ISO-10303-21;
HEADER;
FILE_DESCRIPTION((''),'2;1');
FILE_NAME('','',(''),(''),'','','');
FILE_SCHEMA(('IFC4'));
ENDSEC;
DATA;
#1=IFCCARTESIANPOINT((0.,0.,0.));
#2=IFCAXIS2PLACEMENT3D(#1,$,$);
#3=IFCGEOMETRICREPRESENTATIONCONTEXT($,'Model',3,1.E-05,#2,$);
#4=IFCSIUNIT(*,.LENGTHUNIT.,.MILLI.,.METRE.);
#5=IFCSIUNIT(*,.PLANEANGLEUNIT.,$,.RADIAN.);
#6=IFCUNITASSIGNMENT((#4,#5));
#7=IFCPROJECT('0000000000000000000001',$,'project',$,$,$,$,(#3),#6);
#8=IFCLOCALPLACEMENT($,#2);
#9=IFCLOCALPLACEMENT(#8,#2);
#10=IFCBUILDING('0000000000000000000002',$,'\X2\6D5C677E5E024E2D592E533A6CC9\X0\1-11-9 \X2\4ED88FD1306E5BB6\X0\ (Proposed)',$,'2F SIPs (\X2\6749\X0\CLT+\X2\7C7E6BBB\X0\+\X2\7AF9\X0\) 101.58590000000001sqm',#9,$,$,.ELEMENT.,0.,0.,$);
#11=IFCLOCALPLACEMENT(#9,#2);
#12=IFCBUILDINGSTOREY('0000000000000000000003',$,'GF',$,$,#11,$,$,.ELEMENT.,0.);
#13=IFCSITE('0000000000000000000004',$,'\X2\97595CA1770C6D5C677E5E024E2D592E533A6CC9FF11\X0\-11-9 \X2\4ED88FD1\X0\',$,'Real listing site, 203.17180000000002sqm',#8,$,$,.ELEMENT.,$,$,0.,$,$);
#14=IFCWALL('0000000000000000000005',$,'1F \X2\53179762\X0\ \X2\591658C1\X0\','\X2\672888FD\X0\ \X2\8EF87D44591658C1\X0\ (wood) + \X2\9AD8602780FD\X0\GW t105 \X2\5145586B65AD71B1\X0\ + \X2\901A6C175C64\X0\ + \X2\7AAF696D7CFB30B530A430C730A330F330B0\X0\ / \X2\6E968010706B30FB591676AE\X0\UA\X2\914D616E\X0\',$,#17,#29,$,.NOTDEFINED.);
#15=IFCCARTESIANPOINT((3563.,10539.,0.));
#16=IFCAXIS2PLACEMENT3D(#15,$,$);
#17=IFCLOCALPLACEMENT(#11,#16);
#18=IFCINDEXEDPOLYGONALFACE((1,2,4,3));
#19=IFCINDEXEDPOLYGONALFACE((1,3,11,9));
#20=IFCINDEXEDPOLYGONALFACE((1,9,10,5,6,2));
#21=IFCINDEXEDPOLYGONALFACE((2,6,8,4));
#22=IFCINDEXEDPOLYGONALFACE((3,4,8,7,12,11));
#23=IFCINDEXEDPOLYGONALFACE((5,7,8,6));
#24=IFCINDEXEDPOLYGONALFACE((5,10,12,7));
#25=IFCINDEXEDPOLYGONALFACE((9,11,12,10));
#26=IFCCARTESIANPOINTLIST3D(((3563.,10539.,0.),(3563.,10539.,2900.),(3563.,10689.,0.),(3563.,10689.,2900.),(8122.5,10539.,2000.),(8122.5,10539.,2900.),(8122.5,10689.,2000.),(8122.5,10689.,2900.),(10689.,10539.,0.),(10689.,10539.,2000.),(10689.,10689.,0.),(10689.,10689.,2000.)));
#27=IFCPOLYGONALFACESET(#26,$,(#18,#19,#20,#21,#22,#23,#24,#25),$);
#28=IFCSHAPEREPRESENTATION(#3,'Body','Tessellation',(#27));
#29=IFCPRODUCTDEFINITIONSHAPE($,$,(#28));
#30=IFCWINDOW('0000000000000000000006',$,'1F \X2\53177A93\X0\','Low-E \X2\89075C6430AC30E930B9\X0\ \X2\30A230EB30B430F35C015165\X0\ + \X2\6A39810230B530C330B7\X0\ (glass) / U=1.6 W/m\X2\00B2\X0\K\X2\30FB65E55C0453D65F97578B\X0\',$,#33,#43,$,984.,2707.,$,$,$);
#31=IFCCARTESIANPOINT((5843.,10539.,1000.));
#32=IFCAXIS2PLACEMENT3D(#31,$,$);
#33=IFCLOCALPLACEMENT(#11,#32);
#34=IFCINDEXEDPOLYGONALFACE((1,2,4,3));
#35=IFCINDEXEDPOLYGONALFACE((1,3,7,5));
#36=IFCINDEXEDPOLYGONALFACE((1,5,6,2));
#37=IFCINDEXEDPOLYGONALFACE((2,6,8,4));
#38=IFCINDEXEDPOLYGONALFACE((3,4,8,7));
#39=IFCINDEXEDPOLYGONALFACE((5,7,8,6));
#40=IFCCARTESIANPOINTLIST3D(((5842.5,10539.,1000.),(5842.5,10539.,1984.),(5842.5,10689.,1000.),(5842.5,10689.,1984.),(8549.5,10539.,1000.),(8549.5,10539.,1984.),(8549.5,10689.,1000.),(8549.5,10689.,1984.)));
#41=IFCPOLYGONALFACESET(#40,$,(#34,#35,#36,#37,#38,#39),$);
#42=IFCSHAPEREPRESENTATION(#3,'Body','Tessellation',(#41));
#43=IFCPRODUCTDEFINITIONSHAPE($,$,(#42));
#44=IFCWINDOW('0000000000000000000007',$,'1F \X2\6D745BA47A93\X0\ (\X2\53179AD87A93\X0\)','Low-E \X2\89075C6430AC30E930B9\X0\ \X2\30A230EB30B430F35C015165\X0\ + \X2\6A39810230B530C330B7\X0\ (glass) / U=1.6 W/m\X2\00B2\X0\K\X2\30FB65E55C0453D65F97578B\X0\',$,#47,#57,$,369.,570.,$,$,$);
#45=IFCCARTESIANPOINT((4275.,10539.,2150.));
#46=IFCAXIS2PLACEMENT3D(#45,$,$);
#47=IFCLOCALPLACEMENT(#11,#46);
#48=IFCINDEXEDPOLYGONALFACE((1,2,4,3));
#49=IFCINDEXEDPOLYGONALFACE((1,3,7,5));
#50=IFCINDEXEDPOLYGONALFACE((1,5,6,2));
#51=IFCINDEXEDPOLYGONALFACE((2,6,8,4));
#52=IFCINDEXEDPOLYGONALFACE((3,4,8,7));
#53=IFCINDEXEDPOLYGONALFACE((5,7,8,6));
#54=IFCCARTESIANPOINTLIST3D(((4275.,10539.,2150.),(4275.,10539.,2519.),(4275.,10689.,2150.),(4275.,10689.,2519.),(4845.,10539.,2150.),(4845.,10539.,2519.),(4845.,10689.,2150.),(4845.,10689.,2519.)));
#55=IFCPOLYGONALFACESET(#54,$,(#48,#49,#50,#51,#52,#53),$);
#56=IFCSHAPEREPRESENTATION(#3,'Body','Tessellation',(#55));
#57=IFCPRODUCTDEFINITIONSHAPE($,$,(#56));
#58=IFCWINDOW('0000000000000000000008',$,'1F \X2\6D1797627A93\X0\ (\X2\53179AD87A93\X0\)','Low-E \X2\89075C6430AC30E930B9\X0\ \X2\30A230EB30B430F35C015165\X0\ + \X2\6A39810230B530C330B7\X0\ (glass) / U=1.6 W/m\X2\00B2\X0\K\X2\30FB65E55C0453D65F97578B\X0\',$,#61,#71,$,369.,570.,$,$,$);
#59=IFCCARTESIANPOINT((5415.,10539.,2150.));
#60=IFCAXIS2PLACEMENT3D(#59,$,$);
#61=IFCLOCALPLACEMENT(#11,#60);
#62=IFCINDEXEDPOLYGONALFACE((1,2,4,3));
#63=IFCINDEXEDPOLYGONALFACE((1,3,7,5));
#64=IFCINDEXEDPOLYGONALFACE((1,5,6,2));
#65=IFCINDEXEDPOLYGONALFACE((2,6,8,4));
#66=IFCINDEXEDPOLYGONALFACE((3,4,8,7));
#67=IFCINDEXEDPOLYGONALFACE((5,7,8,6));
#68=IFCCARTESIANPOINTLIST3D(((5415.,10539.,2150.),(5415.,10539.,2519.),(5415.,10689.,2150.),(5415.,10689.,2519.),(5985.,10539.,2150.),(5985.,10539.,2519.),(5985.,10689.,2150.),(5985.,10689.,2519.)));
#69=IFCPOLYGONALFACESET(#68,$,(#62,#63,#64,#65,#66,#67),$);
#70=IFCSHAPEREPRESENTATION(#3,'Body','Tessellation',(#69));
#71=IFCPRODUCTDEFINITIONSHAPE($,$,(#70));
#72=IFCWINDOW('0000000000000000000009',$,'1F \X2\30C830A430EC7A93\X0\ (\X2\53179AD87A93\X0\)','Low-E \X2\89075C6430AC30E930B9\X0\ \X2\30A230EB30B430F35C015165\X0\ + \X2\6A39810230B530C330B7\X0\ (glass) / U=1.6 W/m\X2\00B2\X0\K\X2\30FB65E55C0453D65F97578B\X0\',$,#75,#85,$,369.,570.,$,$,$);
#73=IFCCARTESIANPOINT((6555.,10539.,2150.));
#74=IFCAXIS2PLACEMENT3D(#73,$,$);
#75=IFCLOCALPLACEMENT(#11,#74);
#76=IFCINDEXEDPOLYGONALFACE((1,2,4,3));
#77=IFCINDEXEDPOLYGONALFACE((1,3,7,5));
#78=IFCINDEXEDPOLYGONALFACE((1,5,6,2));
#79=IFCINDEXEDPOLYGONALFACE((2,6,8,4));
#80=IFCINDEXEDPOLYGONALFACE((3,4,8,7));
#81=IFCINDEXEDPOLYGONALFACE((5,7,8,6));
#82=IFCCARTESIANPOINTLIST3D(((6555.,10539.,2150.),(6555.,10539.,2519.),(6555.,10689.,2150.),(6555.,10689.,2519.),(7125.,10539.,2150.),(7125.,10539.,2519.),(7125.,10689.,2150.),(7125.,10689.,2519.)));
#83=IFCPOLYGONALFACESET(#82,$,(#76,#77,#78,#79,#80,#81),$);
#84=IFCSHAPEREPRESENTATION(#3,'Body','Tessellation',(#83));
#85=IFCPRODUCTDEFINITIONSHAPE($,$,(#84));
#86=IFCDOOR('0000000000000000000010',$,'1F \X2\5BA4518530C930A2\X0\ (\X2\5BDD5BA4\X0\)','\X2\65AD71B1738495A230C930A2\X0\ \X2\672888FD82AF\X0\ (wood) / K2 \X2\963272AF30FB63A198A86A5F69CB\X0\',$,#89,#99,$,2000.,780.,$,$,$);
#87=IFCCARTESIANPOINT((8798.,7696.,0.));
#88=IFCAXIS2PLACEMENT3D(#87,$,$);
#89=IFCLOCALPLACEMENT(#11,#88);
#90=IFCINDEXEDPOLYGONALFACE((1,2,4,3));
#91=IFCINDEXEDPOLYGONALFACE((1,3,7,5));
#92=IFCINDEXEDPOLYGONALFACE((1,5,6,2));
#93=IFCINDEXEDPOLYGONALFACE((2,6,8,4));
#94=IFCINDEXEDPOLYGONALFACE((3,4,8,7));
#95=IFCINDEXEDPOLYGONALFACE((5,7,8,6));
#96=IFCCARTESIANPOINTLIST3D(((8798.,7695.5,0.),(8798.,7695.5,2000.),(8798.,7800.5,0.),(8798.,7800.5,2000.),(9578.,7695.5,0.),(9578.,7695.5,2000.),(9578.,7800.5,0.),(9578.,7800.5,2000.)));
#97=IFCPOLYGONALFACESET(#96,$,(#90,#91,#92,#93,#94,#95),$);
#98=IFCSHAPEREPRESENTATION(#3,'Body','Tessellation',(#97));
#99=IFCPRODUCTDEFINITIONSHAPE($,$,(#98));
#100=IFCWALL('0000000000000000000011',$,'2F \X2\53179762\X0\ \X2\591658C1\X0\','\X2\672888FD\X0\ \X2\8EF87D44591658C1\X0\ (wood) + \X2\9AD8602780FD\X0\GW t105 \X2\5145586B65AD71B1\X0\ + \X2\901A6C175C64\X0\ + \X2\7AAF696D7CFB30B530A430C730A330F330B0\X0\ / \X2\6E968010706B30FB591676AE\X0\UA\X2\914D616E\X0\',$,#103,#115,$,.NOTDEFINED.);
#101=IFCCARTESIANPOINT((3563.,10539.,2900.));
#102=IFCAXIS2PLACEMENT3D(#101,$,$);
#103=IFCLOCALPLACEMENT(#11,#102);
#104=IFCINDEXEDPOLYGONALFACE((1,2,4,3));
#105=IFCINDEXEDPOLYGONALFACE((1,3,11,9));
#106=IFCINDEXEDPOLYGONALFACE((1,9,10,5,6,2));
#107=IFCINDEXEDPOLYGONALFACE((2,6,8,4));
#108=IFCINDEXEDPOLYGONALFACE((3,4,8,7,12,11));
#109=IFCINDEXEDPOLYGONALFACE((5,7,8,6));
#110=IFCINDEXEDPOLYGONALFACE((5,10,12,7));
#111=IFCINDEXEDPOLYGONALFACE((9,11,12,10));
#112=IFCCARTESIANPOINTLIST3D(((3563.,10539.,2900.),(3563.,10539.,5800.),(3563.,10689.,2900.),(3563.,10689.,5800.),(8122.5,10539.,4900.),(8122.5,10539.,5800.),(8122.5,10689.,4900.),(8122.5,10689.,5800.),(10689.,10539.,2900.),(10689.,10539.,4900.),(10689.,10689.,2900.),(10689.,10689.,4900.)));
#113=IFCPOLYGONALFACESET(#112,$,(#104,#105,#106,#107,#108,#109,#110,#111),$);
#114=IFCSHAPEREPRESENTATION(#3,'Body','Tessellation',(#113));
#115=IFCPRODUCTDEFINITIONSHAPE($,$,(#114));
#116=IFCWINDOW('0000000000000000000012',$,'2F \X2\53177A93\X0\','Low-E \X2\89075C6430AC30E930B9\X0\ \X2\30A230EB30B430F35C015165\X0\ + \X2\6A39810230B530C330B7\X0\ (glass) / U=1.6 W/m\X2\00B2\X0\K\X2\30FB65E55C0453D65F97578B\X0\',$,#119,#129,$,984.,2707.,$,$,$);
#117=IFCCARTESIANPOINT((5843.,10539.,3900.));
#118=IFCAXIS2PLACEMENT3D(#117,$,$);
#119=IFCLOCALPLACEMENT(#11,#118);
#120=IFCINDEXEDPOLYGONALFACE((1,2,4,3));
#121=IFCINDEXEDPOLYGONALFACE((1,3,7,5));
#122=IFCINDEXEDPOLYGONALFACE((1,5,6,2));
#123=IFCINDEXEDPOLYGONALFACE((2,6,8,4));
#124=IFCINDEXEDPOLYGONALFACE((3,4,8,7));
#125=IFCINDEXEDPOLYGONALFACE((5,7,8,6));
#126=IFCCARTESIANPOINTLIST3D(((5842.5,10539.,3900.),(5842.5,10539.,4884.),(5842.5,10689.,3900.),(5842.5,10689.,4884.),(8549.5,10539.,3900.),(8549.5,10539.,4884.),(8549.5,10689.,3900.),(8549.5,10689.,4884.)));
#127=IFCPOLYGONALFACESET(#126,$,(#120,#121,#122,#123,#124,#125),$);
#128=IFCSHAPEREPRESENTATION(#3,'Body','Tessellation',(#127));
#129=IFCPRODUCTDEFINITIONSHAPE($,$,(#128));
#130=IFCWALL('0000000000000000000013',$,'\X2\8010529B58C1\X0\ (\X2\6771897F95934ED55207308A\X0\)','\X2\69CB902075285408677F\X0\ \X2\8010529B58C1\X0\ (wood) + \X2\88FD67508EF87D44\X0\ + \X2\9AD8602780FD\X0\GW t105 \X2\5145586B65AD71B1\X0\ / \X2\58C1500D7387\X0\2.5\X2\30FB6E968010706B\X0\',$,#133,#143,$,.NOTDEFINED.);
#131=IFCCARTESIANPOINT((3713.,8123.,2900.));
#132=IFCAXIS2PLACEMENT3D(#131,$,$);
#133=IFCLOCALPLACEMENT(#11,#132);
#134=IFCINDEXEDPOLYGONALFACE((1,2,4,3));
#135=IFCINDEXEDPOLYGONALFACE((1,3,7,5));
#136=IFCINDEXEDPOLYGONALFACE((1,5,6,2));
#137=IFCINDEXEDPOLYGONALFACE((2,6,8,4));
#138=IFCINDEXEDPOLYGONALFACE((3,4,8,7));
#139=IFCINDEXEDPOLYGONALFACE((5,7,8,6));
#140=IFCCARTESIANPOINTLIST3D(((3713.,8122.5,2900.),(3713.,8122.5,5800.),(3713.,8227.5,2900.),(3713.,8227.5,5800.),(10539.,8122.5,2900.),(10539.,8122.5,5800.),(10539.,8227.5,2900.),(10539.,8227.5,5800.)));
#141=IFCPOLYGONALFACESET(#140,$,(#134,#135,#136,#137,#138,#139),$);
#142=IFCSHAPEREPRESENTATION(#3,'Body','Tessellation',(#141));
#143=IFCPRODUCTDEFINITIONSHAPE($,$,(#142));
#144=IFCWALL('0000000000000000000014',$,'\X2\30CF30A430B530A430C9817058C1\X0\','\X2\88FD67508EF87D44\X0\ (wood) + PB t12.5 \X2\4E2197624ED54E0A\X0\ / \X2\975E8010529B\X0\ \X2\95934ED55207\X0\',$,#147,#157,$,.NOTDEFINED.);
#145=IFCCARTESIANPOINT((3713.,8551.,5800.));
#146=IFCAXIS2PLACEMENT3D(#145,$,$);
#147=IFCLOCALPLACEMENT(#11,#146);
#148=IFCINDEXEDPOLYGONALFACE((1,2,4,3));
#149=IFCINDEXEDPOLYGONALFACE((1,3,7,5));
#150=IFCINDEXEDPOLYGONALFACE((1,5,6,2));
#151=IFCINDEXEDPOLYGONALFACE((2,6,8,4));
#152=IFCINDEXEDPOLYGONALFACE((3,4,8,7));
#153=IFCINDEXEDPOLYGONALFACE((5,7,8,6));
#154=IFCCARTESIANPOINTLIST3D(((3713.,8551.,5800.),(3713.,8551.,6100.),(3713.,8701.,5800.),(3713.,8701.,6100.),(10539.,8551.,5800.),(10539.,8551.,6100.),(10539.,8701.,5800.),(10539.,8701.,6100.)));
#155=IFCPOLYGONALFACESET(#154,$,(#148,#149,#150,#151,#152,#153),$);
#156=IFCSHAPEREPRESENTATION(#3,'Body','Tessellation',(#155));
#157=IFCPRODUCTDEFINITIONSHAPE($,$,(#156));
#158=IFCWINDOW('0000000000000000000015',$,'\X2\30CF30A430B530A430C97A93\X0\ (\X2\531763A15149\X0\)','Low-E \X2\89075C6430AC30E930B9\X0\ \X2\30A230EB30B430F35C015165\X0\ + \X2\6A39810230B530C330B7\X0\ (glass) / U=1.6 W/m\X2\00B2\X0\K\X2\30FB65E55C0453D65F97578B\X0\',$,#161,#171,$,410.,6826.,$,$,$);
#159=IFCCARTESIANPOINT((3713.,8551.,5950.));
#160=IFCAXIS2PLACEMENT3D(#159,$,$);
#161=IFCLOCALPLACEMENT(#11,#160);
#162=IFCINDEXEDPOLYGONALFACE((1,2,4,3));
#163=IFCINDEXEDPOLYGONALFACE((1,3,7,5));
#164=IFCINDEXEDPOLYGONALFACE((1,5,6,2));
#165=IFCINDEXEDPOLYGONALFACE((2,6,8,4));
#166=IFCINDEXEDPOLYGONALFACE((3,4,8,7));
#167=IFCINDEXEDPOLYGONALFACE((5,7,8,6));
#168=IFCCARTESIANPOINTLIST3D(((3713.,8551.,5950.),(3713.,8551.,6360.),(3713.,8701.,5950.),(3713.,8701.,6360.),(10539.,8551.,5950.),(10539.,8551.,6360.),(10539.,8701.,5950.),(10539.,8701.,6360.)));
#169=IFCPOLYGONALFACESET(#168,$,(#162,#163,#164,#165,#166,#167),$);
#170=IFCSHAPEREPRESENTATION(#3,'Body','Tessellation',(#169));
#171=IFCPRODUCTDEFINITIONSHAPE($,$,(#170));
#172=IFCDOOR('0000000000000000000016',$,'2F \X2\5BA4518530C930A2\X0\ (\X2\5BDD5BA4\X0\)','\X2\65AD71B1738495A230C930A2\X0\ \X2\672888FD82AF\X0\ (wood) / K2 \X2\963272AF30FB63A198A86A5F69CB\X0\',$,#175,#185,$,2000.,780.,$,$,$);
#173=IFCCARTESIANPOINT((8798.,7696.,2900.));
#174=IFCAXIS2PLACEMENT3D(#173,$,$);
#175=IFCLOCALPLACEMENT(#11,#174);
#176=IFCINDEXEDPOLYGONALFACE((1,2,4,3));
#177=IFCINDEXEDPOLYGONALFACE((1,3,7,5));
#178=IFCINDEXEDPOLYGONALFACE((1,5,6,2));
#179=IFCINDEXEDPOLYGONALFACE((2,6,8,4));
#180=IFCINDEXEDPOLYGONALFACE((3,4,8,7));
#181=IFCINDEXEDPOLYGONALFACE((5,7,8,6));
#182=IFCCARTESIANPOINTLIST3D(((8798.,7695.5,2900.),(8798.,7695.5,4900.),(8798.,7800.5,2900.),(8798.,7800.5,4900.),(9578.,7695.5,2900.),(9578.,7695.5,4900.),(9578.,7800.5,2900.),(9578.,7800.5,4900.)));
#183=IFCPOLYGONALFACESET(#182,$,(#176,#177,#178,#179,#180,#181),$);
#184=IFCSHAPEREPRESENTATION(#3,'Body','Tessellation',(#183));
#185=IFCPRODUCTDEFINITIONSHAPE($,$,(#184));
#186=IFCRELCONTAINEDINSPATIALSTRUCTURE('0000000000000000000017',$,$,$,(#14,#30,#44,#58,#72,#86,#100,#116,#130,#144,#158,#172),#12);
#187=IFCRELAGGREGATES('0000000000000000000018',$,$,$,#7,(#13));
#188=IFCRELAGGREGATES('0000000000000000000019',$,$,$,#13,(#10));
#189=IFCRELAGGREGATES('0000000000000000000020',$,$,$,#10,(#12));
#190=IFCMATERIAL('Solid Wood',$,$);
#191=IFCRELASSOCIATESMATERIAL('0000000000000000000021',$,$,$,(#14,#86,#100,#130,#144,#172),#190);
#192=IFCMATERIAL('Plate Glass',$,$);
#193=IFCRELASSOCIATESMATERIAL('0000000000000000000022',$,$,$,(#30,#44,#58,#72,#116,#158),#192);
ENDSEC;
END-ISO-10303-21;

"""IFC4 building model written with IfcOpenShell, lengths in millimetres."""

from ifc_helpers import new_model, si_unit, frame, frame_2d, origin, place, context, project, spatial, rectangle, extrude, material, element, fill, save


model = new_model("IFC4")

# Units and contexts
model_context = context("Model", 3, precision=1e-05, world=origin())
ifc_project = project(units=[si_unit("LENGTHUNIT", "METRE", prefix="MILLI"), si_unit("PLANEANGLEUNIT", "RADIAN")], contexts=[model_context])

# Site, building, storey
site_placement = place(None, origin())
site = spatial("IfcSite", under=ifc_project, at=site_placement, Name="静岡県浜松市中央区泉１-11-9 付近", ObjectType="Real listing site, 203.17180000000002sqm", CompositionType="ELEMENT", RefElevation=0.0)
building_placement = place(site_placement, origin())
building = spatial("IfcBuilding", under=site, at=building_placement, Name="浜松市中央区泉1-11-9 付近の家 (Proposed)", ObjectType="2F SIPs (杉CLT+籾殻+竹) 101.58590000000001sqm", CompositionType="ELEMENT", ElevationOfRefHeight=0.0, ElevationOfTerrain=0.0)
storey_placement = place(building_placement, origin())
storey = spatial("IfcBuildingStorey", under=building, at=storey_placement, Name="GF", CompositionType="ELEMENT", Elevation=0.0)

# Wall, openings, windows
ifc_material_1 = material(Name="Solid Wood")
wall_1_placement = place(storey_placement, frame((3563.0, 10539.0, 0.0)))
wall_1 = element("IfcWall", 1, at=wall_1_placement, inside=storey, material=ifc_material_1, Name="1F 北面 外壁", Description="木製 軸組外壁 (wood) + 高性能GW t105 充填断熱 + 通気層 + 窯業系サイディング / 準耐火・外皮UA配慮", PredefinedType="NOTDEFINED", context=model_context, shape_type="SweptSolid", body=[
    extrude(rectangle(XDim=7126.0, YDim=150.0, at=frame_2d((3563.0, 75.0))), frame((3563.0, 10539.0, 0.0)), (0.0, 0.0, 1.0), 2900.0),
])
opening_1_placement = place(storey_placement, frame((5843.0, 10539.0, 1000.0)))
opening_1 = element("IfcOpeningElement", 2, at=opening_1_placement, cuts=wall_1, PredefinedType="NOTDEFINED", context=model_context, shape_type="SweptSolid", body=[
    extrude(rectangle(XDim=2707.0, YDim=150.0, at=frame_2d((1353.0, 75.0))), frame((5843.0, 10539.0, 1000.0)), (0.0, 0.0, 1.0), 984.0),
])
opening_2_placement = place(storey_placement, frame((4275.0, 10539.0, 2150.0)))
opening_2 = element("IfcOpeningElement", 3, at=opening_2_placement, cuts=wall_1, PredefinedType="NOTDEFINED", context=model_context, shape_type="SweptSolid", body=[
    extrude(rectangle(XDim=570.0, YDim=150.0, at=frame_2d((285.0, 75.0))), frame((4275.0, 10539.0, 2150.0)), (0.0, 0.0, 1.0), 369.0),
])
opening_3_placement = place(storey_placement, frame((5415.0, 10539.0, 2150.0)))
opening_3 = element("IfcOpeningElement", 4, at=opening_3_placement, cuts=wall_1, PredefinedType="NOTDEFINED", context=model_context, shape_type="SweptSolid", body=[
    extrude(rectangle(XDim=570.0, YDim=150.0, at=frame_2d((285.0, 75.0))), frame((5415.0, 10539.0, 2150.0)), (0.0, 0.0, 1.0), 369.0),
])
opening_4_placement = place(storey_placement, frame((6555.0, 10539.0, 2150.0)))
opening_4 = element("IfcOpeningElement", 5, at=opening_4_placement, cuts=wall_1, PredefinedType="NOTDEFINED", context=model_context, shape_type="SweptSolid", body=[
    extrude(rectangle(XDim=570.0, YDim=150.0, at=frame_2d((285.0, 75.0))), frame((6555.0, 10539.0, 2150.0)), (0.0, 0.0, 1.0), 369.0),
])
ifc_material_2 = material(Name="Plate Glass")
window_1_placement = place(storey_placement, frame((5843.0, 10539.0, 1000.0)))
window_1 = element("IfcWindow", 6, at=window_1_placement, inside=storey, material=ifc_material_2, Name="1F 北窓", Description="Low-E 複層ガラス アルゴン封入 + 樹脂サッシ (glass) / U=1.6 W/m²K・日射取得型", OverallHeight=984.0, OverallWidth=2707.0, context=model_context, shape_type="SweptSolid", body=[
    extrude(rectangle(XDim=2707.0, YDim=150.0, at=frame_2d((1353.0, 75.0))), frame((5843.0, 10539.0, 1000.0)), (0.0, 0.0, 1.0), 984.0),
])
fill(opening_1, window_1)
window_2_placement = place(storey_placement, frame((4275.0, 10539.0, 2150.0)))
window_2 = element("IfcWindow", 7, at=window_2_placement, inside=storey, material=ifc_material_2, Name="1F 浴室窓 (北高窓)", Description="Low-E 複層ガラス アルゴン封入 + 樹脂サッシ (glass) / U=1.6 W/m²K・日射取得型", OverallHeight=369.0, OverallWidth=570.0, context=model_context, shape_type="SweptSolid", body=[
    extrude(rectangle(XDim=570.0, YDim=150.0, at=frame_2d((285.0, 75.0))), frame((4275.0, 10539.0, 2150.0)), (0.0, 0.0, 1.0), 369.0),
])
fill(opening_2, window_2)
window_3_placement = place(storey_placement, frame((5415.0, 10539.0, 2150.0)))
window_3 = element("IfcWindow", 8, at=window_3_placement, inside=storey, material=ifc_material_2, Name="1F 洗面窓 (北高窓)", Description="Low-E 複層ガラス アルゴン封入 + 樹脂サッシ (glass) / U=1.6 W/m²K・日射取得型", OverallHeight=369.0, OverallWidth=570.0, context=model_context, shape_type="SweptSolid", body=[
    extrude(rectangle(XDim=570.0, YDim=150.0, at=frame_2d((285.0, 75.0))), frame((5415.0, 10539.0, 2150.0)), (0.0, 0.0, 1.0), 369.0),
])
fill(opening_3, window_3)
window_4_placement = place(storey_placement, frame((6555.0, 10539.0, 2150.0)))
window_4 = element("IfcWindow", 9, at=window_4_placement, inside=storey, material=ifc_material_2, Name="1F トイレ窓 (北高窓)", Description="Low-E 複層ガラス アルゴン封入 + 樹脂サッシ (glass) / U=1.6 W/m²K・日射取得型", OverallHeight=369.0, OverallWidth=570.0, context=model_context, shape_type="SweptSolid", body=[
    extrude(rectangle(XDim=570.0, YDim=150.0, at=frame_2d((285.0, 75.0))), frame((6555.0, 10539.0, 2150.0)), (0.0, 0.0, 1.0), 369.0),
])
fill(opening_4, window_4)

# Door
door_1_placement = place(storey_placement, frame((8798.0, 7696.0, 0.0)))
element("IfcDoor", 10, at=door_1_placement, inside=storey, material=ifc_material_1, Name="1F 室内ドア (寝室)", Description="断熱玄関ドア 木製芯 (wood) / K2 防犯・採風機構", OverallHeight=2000.0, OverallWidth=780.0, context=model_context, shape_type="SweptSolid", body=[
    extrude(rectangle(XDim=780.0, YDim=105.0, at=frame_2d((390.0, 52.0))), frame((8798.0, 7696.0, 0.0)), (0.0, 0.0, 1.0), 2000.0),
])

# Wall, opening, window
wall_2_placement = place(storey_placement, frame((3563.0, 10539.0, 2900.0)))
wall_2 = element("IfcWall", 11, at=wall_2_placement, inside=storey, material=ifc_material_1, Name="2F 北面 外壁", Description="木製 軸組外壁 (wood) + 高性能GW t105 充填断熱 + 通気層 + 窯業系サイディング / 準耐火・外皮UA配慮", PredefinedType="NOTDEFINED", context=model_context, shape_type="SweptSolid", body=[
    extrude(rectangle(XDim=7126.0, YDim=150.0, at=frame_2d((3563.0, 75.0))), frame((3563.0, 10539.0, 2900.0)), (0.0, 0.0, 1.0), 2900.0),
])
opening_5_placement = place(storey_placement, frame((5843.0, 10539.0, 3900.0)))
opening_5 = element("IfcOpeningElement", 12, at=opening_5_placement, cuts=wall_2, PredefinedType="NOTDEFINED", context=model_context, shape_type="SweptSolid", body=[
    extrude(rectangle(XDim=2707.0, YDim=150.0, at=frame_2d((1353.0, 75.0))), frame((5843.0, 10539.0, 3900.0)), (0.0, 0.0, 1.0), 984.0),
])
window_5_placement = place(storey_placement, frame((5843.0, 10539.0, 3900.0)))
window_5 = element("IfcWindow", 13, at=window_5_placement, inside=storey, material=ifc_material_2, Name="2F 北窓", Description="Low-E 複層ガラス アルゴン封入 + 樹脂サッシ (glass) / U=1.6 W/m²K・日射取得型", OverallHeight=984.0, OverallWidth=2707.0, context=model_context, shape_type="SweptSolid", body=[
    extrude(rectangle(XDim=2707.0, YDim=150.0, at=frame_2d((1353.0, 75.0))), frame((5843.0, 10539.0, 3900.0)), (0.0, 0.0, 1.0), 984.0),
])
fill(opening_5, window_5)

# Wall
wall_3_placement = place(storey_placement, frame((3713.0, 8123.0, 2900.0)))
element("IfcWall", 14, at=wall_3_placement, inside=storey, material=ifc_material_1, Name="耐力壁 (東西間仕切り)", Description="構造用合板 耐力壁 (wood) + 製材軸組 + 高性能GW t105 充填断熱 / 壁倍率2.5・準耐火", PredefinedType="NOTDEFINED", context=model_context, shape_type="SweptSolid", body=[
    extrude(rectangle(XDim=6826.0, YDim=105.0, at=frame_2d((3413.0, 52.0))), frame((3713.0, 8123.0, 2900.0)), (0.0, 0.0, 1.0), 2900.0),
])

# Wall, opening, window
wall_4_placement = place(storey_placement, frame((3713.0, 8551.0, 5800.0)))
wall_4 = element("IfcWall", 15, at=wall_4_placement, inside=storey, material=ifc_material_1, Name="ハイサイド腰壁", Description="製材軸組 (wood) + PB t12.5 両面仕上 / 非耐力 間仕切", PredefinedType="NOTDEFINED", context=model_context, shape_type="SweptSolid", body=[
    extrude(rectangle(XDim=6826.0, YDim=150.0, at=frame_2d((3413.0, 75.0))), frame((3713.0, 8551.0, 5800.0)), (0.0, 0.0, 1.0), 700.0),
])
opening_6_placement = place(storey_placement, frame((3713.0, 8551.0, 5950.0)))
opening_6 = element("IfcOpeningElement", 16, at=opening_6_placement, cuts=wall_4, PredefinedType="NOTDEFINED", context=model_context, shape_type="SweptSolid", body=[
    extrude(rectangle(XDim=6826.0, YDim=150.0, at=frame_2d((3413.0, 75.0))), frame((3713.0, 8551.0, 5950.0)), (0.0, 0.0, 1.0), 410.0),
])
window_6_placement = place(storey_placement, frame((3713.0, 8551.0, 5950.0)))
window_6 = element("IfcWindow", 17, at=window_6_placement, inside=storey, material=ifc_material_2, Name="ハイサイド窓 (北採光)", Description="Low-E 複層ガラス アルゴン封入 + 樹脂サッシ (glass) / U=1.6 W/m²K・日射取得型", OverallHeight=410.0, OverallWidth=6826.0, context=model_context, shape_type="SweptSolid", body=[
    extrude(rectangle(XDim=6826.0, YDim=150.0, at=frame_2d((3413.0, 75.0))), frame((3713.0, 8551.0, 5950.0)), (0.0, 0.0, 1.0), 410.0),
])
fill(opening_6, window_6)

# Door
door_2_placement = place(storey_placement, frame((8798.0, 7696.0, 2900.0)))
element("IfcDoor", 18, at=door_2_placement, inside=storey, material=ifc_material_1, Name="2F 室内ドア (寝室)", Description="断熱玄関ドア 木製芯 (wood) / K2 防犯・採風機構", OverallHeight=2000.0, OverallWidth=780.0, context=model_context, shape_type="SweptSolid", body=[
    extrude(rectangle(XDim=780.0, YDim=105.0, at=frame_2d((390.0, 52.0))), frame((8798.0, 7696.0, 2900.0)), (0.0, 0.0, 1.0), 2000.0),
])

save(model, "model.ifc")
